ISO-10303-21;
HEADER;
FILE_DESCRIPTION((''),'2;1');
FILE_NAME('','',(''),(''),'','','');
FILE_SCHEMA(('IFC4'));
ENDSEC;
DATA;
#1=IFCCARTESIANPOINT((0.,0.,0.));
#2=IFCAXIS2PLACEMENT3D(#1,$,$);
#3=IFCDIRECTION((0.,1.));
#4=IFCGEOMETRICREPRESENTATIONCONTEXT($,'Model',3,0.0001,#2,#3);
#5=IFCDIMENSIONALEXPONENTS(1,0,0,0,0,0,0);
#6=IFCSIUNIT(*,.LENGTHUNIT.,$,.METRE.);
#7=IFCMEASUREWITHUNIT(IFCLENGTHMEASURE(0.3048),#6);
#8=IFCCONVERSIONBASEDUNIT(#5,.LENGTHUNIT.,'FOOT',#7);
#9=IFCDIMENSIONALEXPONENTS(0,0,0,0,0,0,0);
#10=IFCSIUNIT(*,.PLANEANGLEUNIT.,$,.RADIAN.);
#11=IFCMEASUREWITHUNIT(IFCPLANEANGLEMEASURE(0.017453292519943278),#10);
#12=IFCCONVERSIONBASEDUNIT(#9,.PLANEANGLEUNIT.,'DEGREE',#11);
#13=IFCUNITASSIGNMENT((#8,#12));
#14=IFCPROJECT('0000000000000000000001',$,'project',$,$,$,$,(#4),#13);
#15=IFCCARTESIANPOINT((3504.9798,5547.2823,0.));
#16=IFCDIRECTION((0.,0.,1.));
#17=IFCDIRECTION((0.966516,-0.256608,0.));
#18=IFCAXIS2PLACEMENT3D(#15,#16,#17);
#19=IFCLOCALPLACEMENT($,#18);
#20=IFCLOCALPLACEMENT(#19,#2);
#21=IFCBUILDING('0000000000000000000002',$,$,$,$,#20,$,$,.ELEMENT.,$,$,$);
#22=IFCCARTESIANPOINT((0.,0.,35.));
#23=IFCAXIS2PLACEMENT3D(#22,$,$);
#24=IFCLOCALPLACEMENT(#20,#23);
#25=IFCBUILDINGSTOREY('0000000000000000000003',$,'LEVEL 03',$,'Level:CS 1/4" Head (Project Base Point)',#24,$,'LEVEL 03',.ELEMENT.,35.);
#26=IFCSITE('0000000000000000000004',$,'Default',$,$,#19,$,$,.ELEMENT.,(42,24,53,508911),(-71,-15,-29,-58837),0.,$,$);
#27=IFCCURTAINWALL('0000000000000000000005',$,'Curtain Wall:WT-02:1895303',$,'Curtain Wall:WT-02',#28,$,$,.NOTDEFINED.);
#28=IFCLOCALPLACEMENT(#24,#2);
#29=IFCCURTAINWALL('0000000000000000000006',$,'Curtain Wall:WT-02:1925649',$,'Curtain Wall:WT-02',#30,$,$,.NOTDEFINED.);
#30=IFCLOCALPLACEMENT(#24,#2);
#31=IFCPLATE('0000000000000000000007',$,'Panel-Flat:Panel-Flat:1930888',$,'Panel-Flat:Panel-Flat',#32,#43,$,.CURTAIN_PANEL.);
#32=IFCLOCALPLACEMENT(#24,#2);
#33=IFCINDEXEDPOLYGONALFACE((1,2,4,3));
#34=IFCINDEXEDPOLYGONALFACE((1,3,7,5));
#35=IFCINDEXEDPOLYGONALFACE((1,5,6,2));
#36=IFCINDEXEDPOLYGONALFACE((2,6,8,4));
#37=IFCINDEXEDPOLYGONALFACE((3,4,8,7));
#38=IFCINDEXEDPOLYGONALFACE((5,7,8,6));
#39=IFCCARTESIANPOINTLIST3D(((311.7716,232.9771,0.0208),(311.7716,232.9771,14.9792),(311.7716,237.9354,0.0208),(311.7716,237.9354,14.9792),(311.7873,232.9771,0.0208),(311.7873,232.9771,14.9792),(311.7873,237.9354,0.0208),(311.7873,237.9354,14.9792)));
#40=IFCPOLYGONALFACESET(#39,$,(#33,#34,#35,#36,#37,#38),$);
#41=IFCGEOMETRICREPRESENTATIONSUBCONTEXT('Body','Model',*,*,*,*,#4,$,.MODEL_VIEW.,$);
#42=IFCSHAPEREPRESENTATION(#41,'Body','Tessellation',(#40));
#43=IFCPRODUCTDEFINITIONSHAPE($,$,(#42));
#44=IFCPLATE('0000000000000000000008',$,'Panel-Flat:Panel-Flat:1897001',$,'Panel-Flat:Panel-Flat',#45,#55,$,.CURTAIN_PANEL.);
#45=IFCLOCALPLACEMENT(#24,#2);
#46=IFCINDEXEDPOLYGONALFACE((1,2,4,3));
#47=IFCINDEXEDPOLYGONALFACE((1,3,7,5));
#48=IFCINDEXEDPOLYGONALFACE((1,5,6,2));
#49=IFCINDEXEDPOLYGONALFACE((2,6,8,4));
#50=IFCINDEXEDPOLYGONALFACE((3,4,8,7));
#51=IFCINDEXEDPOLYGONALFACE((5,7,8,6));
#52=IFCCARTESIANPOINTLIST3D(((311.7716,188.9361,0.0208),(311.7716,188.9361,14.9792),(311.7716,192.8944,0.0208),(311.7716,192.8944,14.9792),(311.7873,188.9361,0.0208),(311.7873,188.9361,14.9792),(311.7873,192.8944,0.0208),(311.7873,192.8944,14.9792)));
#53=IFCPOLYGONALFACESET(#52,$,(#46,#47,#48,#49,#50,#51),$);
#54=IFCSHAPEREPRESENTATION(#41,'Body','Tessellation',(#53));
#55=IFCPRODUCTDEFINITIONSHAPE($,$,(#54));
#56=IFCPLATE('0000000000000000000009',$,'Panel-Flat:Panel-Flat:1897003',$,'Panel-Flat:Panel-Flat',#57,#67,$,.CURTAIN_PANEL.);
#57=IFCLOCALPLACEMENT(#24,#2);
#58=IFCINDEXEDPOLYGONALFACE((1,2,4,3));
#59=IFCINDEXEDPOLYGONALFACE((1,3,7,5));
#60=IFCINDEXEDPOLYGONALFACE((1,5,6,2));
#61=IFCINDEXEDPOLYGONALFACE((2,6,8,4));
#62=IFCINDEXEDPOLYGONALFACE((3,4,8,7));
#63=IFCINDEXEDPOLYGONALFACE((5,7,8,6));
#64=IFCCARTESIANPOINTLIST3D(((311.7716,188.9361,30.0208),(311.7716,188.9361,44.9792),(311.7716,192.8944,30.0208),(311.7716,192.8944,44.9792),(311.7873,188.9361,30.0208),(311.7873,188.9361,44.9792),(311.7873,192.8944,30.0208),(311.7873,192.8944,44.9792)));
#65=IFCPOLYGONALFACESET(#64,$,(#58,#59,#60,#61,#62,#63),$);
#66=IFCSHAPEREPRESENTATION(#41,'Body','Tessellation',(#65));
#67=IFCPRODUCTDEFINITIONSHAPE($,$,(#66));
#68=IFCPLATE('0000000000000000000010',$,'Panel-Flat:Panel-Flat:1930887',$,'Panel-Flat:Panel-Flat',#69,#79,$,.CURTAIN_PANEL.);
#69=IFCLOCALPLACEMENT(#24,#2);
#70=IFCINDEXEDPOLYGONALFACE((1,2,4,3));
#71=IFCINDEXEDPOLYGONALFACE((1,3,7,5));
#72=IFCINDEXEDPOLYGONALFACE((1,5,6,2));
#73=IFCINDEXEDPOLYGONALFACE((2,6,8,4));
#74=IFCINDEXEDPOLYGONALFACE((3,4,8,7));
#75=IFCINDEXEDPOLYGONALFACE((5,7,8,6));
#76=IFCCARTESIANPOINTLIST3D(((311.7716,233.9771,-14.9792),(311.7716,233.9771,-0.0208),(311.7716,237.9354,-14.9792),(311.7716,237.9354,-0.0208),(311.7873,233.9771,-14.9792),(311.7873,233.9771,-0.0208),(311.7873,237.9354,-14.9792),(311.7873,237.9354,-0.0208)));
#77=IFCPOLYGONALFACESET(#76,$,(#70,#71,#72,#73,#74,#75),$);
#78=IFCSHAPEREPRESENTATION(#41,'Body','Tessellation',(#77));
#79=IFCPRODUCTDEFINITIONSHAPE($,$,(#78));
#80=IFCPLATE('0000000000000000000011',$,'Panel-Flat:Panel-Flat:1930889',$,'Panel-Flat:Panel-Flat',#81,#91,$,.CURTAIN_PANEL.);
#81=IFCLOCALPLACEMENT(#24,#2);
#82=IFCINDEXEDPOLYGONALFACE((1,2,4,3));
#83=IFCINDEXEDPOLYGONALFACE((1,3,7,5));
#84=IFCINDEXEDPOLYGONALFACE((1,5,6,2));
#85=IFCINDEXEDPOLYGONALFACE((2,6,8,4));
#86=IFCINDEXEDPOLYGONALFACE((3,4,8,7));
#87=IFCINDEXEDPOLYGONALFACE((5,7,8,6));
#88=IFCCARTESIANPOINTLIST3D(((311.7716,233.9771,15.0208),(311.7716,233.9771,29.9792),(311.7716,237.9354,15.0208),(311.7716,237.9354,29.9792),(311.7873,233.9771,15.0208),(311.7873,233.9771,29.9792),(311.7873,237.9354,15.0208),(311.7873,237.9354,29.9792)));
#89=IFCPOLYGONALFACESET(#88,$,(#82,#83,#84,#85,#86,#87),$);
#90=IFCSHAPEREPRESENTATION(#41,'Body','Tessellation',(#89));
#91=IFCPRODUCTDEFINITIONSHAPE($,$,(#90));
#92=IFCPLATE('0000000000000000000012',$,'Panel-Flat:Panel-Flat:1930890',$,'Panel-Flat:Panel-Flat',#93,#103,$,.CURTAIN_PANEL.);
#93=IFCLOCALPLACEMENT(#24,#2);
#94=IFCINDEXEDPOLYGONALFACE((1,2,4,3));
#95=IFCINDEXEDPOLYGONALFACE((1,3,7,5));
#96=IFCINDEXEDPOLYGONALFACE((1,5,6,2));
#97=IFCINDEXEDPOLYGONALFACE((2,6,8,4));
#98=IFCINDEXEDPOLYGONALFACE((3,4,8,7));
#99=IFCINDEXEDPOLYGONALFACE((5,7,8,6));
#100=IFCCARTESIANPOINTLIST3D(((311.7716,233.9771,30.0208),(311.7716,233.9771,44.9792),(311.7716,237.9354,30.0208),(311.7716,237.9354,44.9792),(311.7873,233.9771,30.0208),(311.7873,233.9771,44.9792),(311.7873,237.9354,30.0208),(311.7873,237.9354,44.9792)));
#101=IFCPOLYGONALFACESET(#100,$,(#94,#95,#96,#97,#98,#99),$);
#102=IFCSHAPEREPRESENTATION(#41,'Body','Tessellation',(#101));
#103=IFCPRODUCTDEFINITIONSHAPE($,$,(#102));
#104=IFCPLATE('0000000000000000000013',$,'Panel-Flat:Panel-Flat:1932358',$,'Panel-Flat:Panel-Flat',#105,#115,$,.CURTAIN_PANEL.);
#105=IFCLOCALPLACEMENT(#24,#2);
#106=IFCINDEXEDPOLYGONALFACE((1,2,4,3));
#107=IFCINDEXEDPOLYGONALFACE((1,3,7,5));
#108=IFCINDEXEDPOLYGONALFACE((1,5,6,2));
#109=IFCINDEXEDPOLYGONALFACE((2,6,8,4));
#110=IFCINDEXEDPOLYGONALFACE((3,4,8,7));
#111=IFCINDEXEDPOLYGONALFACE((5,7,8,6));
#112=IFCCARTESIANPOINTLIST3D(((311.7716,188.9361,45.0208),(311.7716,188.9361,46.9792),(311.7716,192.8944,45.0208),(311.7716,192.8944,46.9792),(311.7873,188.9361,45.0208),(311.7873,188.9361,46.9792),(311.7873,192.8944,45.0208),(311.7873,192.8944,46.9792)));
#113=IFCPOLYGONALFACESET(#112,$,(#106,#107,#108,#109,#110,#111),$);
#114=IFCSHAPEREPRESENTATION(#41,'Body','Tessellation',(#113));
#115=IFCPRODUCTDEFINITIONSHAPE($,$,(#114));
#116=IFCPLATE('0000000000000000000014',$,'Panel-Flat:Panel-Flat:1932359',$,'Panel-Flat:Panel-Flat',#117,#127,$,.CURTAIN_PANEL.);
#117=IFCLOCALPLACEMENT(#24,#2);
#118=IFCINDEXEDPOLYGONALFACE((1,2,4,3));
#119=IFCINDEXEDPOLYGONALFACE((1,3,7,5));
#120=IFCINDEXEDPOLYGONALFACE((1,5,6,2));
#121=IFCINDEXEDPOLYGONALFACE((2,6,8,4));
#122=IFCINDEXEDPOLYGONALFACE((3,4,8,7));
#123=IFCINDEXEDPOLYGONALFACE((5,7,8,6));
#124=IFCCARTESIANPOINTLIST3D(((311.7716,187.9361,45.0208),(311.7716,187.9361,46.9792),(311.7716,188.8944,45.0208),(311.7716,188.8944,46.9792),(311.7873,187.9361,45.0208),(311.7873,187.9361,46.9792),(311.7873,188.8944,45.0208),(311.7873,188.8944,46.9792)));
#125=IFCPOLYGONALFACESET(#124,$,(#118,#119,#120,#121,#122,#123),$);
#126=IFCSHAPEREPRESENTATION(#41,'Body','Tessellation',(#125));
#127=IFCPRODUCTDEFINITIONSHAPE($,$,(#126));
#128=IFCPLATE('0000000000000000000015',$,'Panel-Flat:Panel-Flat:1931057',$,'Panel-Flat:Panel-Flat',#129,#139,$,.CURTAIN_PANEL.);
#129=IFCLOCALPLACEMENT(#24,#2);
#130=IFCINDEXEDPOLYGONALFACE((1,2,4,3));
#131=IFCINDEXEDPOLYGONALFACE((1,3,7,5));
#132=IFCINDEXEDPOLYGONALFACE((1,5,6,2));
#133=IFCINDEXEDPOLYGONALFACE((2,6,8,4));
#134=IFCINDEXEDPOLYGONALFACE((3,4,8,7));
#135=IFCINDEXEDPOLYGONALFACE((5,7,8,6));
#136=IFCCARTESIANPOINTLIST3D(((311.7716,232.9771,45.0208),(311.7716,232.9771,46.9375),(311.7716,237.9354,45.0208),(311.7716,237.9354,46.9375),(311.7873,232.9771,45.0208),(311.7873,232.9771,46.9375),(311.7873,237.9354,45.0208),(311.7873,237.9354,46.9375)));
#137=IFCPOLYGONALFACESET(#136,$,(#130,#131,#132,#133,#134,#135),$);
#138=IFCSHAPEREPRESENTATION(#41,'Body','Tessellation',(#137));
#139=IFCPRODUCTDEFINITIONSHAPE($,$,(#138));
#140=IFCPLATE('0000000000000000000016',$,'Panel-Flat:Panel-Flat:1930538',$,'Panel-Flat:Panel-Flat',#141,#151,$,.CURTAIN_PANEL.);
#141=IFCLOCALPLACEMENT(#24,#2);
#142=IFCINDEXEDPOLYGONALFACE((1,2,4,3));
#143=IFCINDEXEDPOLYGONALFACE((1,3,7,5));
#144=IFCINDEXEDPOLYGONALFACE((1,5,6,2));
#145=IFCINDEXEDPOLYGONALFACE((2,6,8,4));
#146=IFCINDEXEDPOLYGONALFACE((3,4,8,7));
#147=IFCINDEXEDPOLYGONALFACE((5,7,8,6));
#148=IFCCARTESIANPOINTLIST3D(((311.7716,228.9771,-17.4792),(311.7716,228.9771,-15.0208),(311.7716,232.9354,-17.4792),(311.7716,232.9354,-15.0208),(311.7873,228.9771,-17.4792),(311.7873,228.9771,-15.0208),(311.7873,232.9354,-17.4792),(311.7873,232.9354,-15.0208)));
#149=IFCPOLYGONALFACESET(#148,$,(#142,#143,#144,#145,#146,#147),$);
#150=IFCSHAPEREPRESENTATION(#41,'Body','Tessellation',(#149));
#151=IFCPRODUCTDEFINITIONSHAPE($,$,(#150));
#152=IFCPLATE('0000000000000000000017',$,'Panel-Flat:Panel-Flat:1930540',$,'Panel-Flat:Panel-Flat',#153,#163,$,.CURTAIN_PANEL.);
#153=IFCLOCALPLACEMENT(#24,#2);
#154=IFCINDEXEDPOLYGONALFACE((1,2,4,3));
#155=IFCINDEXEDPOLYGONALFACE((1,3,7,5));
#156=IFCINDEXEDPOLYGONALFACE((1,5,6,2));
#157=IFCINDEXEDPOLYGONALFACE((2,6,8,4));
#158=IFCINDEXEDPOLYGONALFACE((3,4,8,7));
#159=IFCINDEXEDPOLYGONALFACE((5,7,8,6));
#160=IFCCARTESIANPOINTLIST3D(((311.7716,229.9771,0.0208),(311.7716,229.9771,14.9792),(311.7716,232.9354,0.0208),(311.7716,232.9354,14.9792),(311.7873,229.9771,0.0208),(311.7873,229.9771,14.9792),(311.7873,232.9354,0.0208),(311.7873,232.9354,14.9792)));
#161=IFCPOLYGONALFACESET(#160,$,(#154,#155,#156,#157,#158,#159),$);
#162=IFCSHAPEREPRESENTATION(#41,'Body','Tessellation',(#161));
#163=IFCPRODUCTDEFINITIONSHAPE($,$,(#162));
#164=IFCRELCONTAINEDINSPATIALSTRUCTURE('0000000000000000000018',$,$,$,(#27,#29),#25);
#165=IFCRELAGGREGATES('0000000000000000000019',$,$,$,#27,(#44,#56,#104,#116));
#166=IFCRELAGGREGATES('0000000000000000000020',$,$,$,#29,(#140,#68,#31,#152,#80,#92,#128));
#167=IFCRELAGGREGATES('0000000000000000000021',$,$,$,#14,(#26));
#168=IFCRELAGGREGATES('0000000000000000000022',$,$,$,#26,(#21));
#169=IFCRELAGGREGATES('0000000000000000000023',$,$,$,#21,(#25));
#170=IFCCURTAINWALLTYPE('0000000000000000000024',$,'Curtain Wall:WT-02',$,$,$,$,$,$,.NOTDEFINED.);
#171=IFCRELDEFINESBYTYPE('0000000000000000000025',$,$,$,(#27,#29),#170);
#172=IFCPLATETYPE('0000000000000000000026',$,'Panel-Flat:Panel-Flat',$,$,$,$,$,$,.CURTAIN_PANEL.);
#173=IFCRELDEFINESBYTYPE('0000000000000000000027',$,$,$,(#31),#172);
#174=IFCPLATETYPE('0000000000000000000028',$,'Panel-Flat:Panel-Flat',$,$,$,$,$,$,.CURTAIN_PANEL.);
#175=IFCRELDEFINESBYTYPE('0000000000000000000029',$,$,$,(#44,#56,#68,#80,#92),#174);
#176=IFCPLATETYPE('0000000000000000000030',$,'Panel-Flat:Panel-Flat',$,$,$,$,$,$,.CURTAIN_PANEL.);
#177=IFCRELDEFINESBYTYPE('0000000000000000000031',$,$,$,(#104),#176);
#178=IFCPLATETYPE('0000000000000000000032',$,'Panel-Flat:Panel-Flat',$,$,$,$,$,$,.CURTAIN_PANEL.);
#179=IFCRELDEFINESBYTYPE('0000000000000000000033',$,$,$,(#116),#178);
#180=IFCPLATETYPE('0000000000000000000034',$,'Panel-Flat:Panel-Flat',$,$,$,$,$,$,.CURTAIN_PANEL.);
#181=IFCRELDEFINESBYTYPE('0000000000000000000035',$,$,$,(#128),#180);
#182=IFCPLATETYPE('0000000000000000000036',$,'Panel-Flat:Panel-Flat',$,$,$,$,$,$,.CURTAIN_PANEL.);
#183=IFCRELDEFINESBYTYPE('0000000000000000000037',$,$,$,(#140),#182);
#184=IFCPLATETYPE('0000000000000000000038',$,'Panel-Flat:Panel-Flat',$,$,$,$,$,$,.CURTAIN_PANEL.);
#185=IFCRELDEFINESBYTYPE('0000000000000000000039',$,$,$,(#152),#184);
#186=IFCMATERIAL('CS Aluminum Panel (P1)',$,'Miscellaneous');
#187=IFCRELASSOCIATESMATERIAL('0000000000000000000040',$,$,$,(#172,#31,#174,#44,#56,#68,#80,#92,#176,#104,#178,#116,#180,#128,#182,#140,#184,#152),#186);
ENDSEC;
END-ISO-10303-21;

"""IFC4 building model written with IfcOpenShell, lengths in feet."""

from ifc_helpers import new_model, entity, si_unit, converted_unit, direction, frame, origin, place, context, subcontext, project, spatial, indexed_curve, outline, extrude, source, transform, mapped, material, type_object, type_shapes, element, aggregate, save


model = new_model("IFC4")

# Units and contexts
model_context = context("Model", 3, precision=0.0001, world=origin(), true_north=direction((0.0, 1.0)))
body_context = subcontext(model_context, "Body", "Model", "MODEL_VIEW")
ifc_project = project(units=[converted_unit("LENGTHUNIT", "FOOT", entity("IfcLengthMeasure", 0.3048), si_unit("LENGTHUNIT", "METRE"), dimensions=[1, 0, 0, 0, 0, 0, 0]), converted_unit("PLANEANGLEUNIT", "DEGREE", entity("IfcPlaneAngleMeasure", 0.017453292519943278), si_unit("PLANEANGLEUNIT", "RADIAN"), dimensions=[0, 0, 0, 0, 0, 0, 0])], contexts=[model_context])

# Site, building, storey
site_placement = place(None, frame((3504.9798, 5547.2823, 0.0), z_axis=(0.0, 0.0, 1.0), x_axis=(0.966516, -0.256608, 0.0)))
site = spatial("IfcSite", under=ifc_project, at=site_placement, Name="Default", CompositionType="ELEMENT", RefLatitude=(42, 24, 53, 508911), RefLongitude=(-71, -15, -29, -58837), RefElevation=0.0)
building_placement = place(site_placement, origin())
building = spatial("IfcBuilding", under=site, at=building_placement, CompositionType="ELEMENT")
storey_placement = place(building_placement, frame((0.0, 0.0, 35.0)))
storey = spatial("IfcBuildingStorey", under=building, at=storey_placement, Name="LEVEL 03", ObjectType="Level:CS 1/4\" Head (Project Base Point)", LongName="LEVEL 03", CompositionType="ELEMENT", Elevation=35.0)

# Curtain walls
curtain_wall_type = type_object("IfcCurtainWallType", Name="Curtain Wall:WT-02", PredefinedType="NOTDEFINED")
curtain_wall_1_placement = place(storey_placement, frame((0.0, 0.0, -35.0)))
curtain_wall_1 = element("IfcCurtainWall", 1, at=curtain_wall_1_placement, inside=storey, type_object=curtain_wall_type, Name="Curtain Wall:WT-02:1895303", ObjectType="Curtain Wall:WT-02", PredefinedType="NOTDEFINED")
ifc_material_1 = material(Name="CS Aluminum Panel (P1)", Category="Miscellaneous")
curtain_wall_2_placement = place(storey_placement, frame((0.0, 0.0, -35.0)))
curtain_wall_2 = element("IfcCurtainWall", 2, at=curtain_wall_2_placement, inside=storey, type_object=curtain_wall_type, Name="Curtain Wall:WT-02:1925649", ObjectType="Curtain Wall:WT-02", PredefinedType="NOTDEFINED")

# Plates
plate_type_1 = type_object("IfcPlateType", Name="Panel-Flat:Panel-Flat", PredefinedType="CURTAIN_PANEL", material=ifc_material_1)
shared_shape_1 = source(origin(), body_context, "Body", "SweptSolid", [
    extrude(outline(indexed_curve([(-0.0078, -2.4792), (0.0078, -2.4792), (0.0078, 2.4792), (-0.0078, 2.4792), (-0.0078, -2.4792)], self_intersect=False)), frame((0.0, -0.0078, 0.0208), z_axis=(0.0, 0.0, 1.0), x_axis=(0.0, -1.0, 0.0)), (0.0, 0.0, 1.0), 14.9583),
])
type_shapes(plate_type_1, [shared_shape_1])
plate_1_placement = place(curtain_wall_2_placement, frame((311.7873, 235.4563, 35.0), z_axis=(0.0, 0.0, 1.0), x_axis=(0.0, -1.0, 0.0)))
plate_1 = element("IfcPlate", 3, at=plate_1_placement, type_object=plate_type_1, material=ifc_material_1, Name="Panel-Flat:Panel-Flat:1930888", ObjectType="Panel-Flat:Panel-Flat", PredefinedType="CURTAIN_PANEL", context=body_context, shape_type="MappedRepresentation", body=[
    mapped(shared_shape_1, transform((0.0, 0.0, 0.0), scale=1.0)),
])
plate_type_2 = type_object("IfcPlateType", Name="Panel-Flat:Panel-Flat", PredefinedType="CURTAIN_PANEL", material=ifc_material_1)
shared_shape_2 = source(origin(), body_context, "Body", "SweptSolid", [
    extrude(outline(indexed_curve([(-0.0078, -1.9792), (0.0078, -1.9792), (0.0078, 1.9792), (-0.0078, 1.9792), (-0.0078, -1.9792)], self_intersect=False)), frame((0.0, -0.0078, 0.0208), z_axis=(0.0, 0.0, 1.0), x_axis=(0.0, -1.0, 0.0)), (0.0, 0.0, 1.0), 14.9583),
])
type_shapes(plate_type_2, [shared_shape_2])
plate_2_placement = place(curtain_wall_1_placement, frame((311.7873, 190.9153, 35.0), z_axis=(0.0, 0.0, 1.0), x_axis=(0.0, -1.0, 0.0)))
plate_2 = element("IfcPlate", 4, at=plate_2_placement, type_object=plate_type_2, material=ifc_material_1, Name="Panel-Flat:Panel-Flat:1897001", ObjectType="Panel-Flat:Panel-Flat", PredefinedType="CURTAIN_PANEL", context=body_context, shape_type="MappedRepresentation", body=[
    mapped(shared_shape_2, transform((0.0, 0.0, 0.0), scale=1.0)),
])
plate_3_placement = place(curtain_wall_1_placement, frame((311.7873, 190.9153, 65.0), z_axis=(0.0, 0.0, 1.0), x_axis=(0.0, -1.0, 0.0)))
plate_3 = element("IfcPlate", 5, at=plate_3_placement, type_object=plate_type_2, material=ifc_material_1, Name="Panel-Flat:Panel-Flat:1897003", ObjectType="Panel-Flat:Panel-Flat", PredefinedType="CURTAIN_PANEL", context=body_context, shape_type="MappedRepresentation", body=[
    mapped(shared_shape_2, transform((0.0, 0.0, 0.0), scale=1.0)),
])
plate_4_placement = place(curtain_wall_2_placement, frame((311.7873, 235.9563, 20.0), z_axis=(0.0, 0.0, 1.0), x_axis=(0.0, -1.0, 0.0)))
plate_4 = element("IfcPlate", 6, at=plate_4_placement, type_object=plate_type_2, material=ifc_material_1, Name="Panel-Flat:Panel-Flat:1930887", ObjectType="Panel-Flat:Panel-Flat", PredefinedType="CURTAIN_PANEL", context=body_context, shape_type="MappedRepresentation", body=[
    mapped(shared_shape_2, transform((0.0, 0.0, 0.0), scale=1.0)),
])
plate_5_placement = place(curtain_wall_2_placement, frame((311.7873, 235.9563, 50.0), z_axis=(0.0, 0.0, 1.0), x_axis=(0.0, -1.0, 0.0)))
plate_5 = element("IfcPlate", 7, at=plate_5_placement, type_object=plate_type_2, material=ifc_material_1, Name="Panel-Flat:Panel-Flat:1930889", ObjectType="Panel-Flat:Panel-Flat", PredefinedType="CURTAIN_PANEL", context=body_context, shape_type="MappedRepresentation", body=[
    mapped(shared_shape_2, transform((0.0, 0.0, 0.0), scale=1.0)),
])
plate_6_placement = place(curtain_wall_2_placement, frame((311.7873, 235.9563, 65.0), z_axis=(0.0, 0.0, 1.0), x_axis=(0.0, -1.0, 0.0)))
plate_6 = element("IfcPlate", 8, at=plate_6_placement, type_object=plate_type_2, material=ifc_material_1, Name="Panel-Flat:Panel-Flat:1930890", ObjectType="Panel-Flat:Panel-Flat", PredefinedType="CURTAIN_PANEL", context=body_context, shape_type="MappedRepresentation", body=[
    mapped(shared_shape_2, transform((0.0, 0.0, 0.0), scale=1.0)),
])
plate_type_3 = type_object("IfcPlateType", Name="Panel-Flat:Panel-Flat", PredefinedType="CURTAIN_PANEL", material=ifc_material_1)
shared_shape_3 = source(origin(), body_context, "Body", "SweptSolid", [
    extrude(outline(indexed_curve([(-0.0078, -1.9792), (0.0078, -1.9792), (0.0078, 1.9792), (-0.0078, 1.9792), (-0.0078, -1.9792)], self_intersect=False)), frame((0.0, -0.0078, 0.0208), z_axis=(0.0, 0.0, 1.0), x_axis=(0.0, -1.0, 0.0)), (0.0, 0.0, 1.0), 1.9583),
])
type_shapes(plate_type_3, [shared_shape_3])
plate_7_placement = place(curtain_wall_1_placement, frame((311.7873, 190.9153, 80.0), z_axis=(0.0, 0.0, 1.0), x_axis=(0.0, -1.0, 0.0)))
plate_7 = element("IfcPlate", 9, at=plate_7_placement, type_object=plate_type_3, material=ifc_material_1, Name="Panel-Flat:Panel-Flat:1932358", ObjectType="Panel-Flat:Panel-Flat", PredefinedType="CURTAIN_PANEL", context=body_context, shape_type="MappedRepresentation", body=[
    mapped(shared_shape_3, transform((0.0, 0.0, 0.0), scale=1.0)),
])
plate_type_4 = type_object("IfcPlateType", Name="Panel-Flat:Panel-Flat", PredefinedType="CURTAIN_PANEL", material=ifc_material_1)
shared_shape_4 = source(origin(), body_context, "Body", "SweptSolid", [
    extrude(outline(indexed_curve([(-0.0078, -0.4792), (0.0078, -0.4792), (0.0078, 0.4792), (-0.0078, 0.4792), (-0.0078, -0.4792)], self_intersect=False)), frame((0.0, -0.0078, 0.0208), z_axis=(0.0, 0.0, 1.0), x_axis=(0.0, -1.0, 0.0)), (0.0, 0.0, 1.0), 1.9583),
])
type_shapes(plate_type_4, [shared_shape_4])
plate_8_placement = place(curtain_wall_1_placement, frame((311.7873, 188.4153, 80.0), z_axis=(0.0, 0.0, 1.0), x_axis=(0.0, -1.0, 0.0)))
plate_8 = element("IfcPlate", 10, at=plate_8_placement, type_object=plate_type_4, material=ifc_material_1, Name="Panel-Flat:Panel-Flat:1932359", ObjectType="Panel-Flat:Panel-Flat", PredefinedType="CURTAIN_PANEL", context=body_context, shape_type="MappedRepresentation", body=[
    mapped(shared_shape_4, transform((0.0, 0.0, 0.0), scale=1.0)),
])
aggregate(curtain_wall_1, [plate_2, plate_3, plate_7, plate_8])
plate_type_5 = type_object("IfcPlateType", Name="Panel-Flat:Panel-Flat", PredefinedType="CURTAIN_PANEL", material=ifc_material_1)
shared_shape_5 = source(origin(), body_context, "Body", "SweptSolid", [
    extrude(outline(indexed_curve([(-0.0078, -2.4792), (0.0078, -2.4792), (0.0078, 2.4792), (-0.0078, 2.4792), (-0.0078, -2.4792)], self_intersect=False)), frame((0.0, -0.0078, 0.0208), z_axis=(0.0, 0.0, 1.0), x_axis=(0.0, -1.0, 0.0)), (0.0, 0.0, 1.0), 1.9167),
])
type_shapes(plate_type_5, [shared_shape_5])
plate_9_placement = place(curtain_wall_2_placement, frame((311.7873, 235.4563, 80.0), z_axis=(0.0, 0.0, 1.0), x_axis=(0.0, -1.0, 0.0)))
plate_9 = element("IfcPlate", 11, at=plate_9_placement, type_object=plate_type_5, material=ifc_material_1, Name="Panel-Flat:Panel-Flat:1931057", ObjectType="Panel-Flat:Panel-Flat", PredefinedType="CURTAIN_PANEL", context=body_context, shape_type="MappedRepresentation", body=[
    mapped(shared_shape_5, transform((0.0, 0.0, 0.0), scale=1.0)),
])
plate_type_6 = type_object("IfcPlateType", Name="Panel-Flat:Panel-Flat", PredefinedType="CURTAIN_PANEL", material=ifc_material_1)
shared_shape_6 = source(origin(), body_context, "Body", "SweptSolid", [
    extrude(outline(indexed_curve([(-0.0078, -1.9792), (0.0078, -1.9792), (0.0078, 1.9792), (-0.0078, 1.9792), (-0.0078, -1.9792)], self_intersect=False)), frame((0.0, -0.0078, 0.0208), z_axis=(0.0, 0.0, 1.0), x_axis=(0.0, -1.0, 0.0)), (0.0, 0.0, 1.0), 2.4583),
])
type_shapes(plate_type_6, [shared_shape_6])
plate_10_placement = place(curtain_wall_2_placement, frame((311.7873, 230.9563, 17.5), z_axis=(0.0, 0.0, 1.0), x_axis=(0.0, -1.0, 0.0)))
plate_10 = element("IfcPlate", 12, at=plate_10_placement, type_object=plate_type_6, material=ifc_material_1, Name="Panel-Flat:Panel-Flat:1930538", ObjectType="Panel-Flat:Panel-Flat", PredefinedType="CURTAIN_PANEL", context=body_context, shape_type="MappedRepresentation", body=[
    mapped(shared_shape_6, transform((0.0, 0.0, 0.0), scale=1.0)),
])
plate_type_7 = type_object("IfcPlateType", Name="Panel-Flat:Panel-Flat", PredefinedType="CURTAIN_PANEL", material=ifc_material_1)
shared_shape_7 = source(origin(), body_context, "Body", "SweptSolid", [
    extrude(outline(indexed_curve([(-0.0078, -1.4792), (0.0078, -1.4792), (0.0078, 1.4792), (-0.0078, 1.4792), (-0.0078, -1.4792)], self_intersect=False)), frame((0.0, -0.0078, 0.0208), z_axis=(0.0, 0.0, 1.0), x_axis=(0.0, -1.0, 0.0)), (0.0, 0.0, 1.0), 14.9583),
])
type_shapes(plate_type_7, [shared_shape_7])
plate_11_placement = place(curtain_wall_2_placement, frame((311.7873, 231.4563, 35.0), z_axis=(0.0, 0.0, 1.0), x_axis=(0.0, -1.0, 0.0)))
plate_11 = element("IfcPlate", 13, at=plate_11_placement, type_object=plate_type_7, material=ifc_material_1, Name="Panel-Flat:Panel-Flat:1930540", ObjectType="Panel-Flat:Panel-Flat", PredefinedType="CURTAIN_PANEL", context=body_context, shape_type="MappedRepresentation", body=[
    mapped(shared_shape_7, transform((0.0, 0.0, 0.0), scale=1.0)),
])
aggregate(curtain_wall_2, [plate_10, plate_4, plate_1, plate_11, plate_5, plate_6, plate_9])

save(model, "model.ifc")
